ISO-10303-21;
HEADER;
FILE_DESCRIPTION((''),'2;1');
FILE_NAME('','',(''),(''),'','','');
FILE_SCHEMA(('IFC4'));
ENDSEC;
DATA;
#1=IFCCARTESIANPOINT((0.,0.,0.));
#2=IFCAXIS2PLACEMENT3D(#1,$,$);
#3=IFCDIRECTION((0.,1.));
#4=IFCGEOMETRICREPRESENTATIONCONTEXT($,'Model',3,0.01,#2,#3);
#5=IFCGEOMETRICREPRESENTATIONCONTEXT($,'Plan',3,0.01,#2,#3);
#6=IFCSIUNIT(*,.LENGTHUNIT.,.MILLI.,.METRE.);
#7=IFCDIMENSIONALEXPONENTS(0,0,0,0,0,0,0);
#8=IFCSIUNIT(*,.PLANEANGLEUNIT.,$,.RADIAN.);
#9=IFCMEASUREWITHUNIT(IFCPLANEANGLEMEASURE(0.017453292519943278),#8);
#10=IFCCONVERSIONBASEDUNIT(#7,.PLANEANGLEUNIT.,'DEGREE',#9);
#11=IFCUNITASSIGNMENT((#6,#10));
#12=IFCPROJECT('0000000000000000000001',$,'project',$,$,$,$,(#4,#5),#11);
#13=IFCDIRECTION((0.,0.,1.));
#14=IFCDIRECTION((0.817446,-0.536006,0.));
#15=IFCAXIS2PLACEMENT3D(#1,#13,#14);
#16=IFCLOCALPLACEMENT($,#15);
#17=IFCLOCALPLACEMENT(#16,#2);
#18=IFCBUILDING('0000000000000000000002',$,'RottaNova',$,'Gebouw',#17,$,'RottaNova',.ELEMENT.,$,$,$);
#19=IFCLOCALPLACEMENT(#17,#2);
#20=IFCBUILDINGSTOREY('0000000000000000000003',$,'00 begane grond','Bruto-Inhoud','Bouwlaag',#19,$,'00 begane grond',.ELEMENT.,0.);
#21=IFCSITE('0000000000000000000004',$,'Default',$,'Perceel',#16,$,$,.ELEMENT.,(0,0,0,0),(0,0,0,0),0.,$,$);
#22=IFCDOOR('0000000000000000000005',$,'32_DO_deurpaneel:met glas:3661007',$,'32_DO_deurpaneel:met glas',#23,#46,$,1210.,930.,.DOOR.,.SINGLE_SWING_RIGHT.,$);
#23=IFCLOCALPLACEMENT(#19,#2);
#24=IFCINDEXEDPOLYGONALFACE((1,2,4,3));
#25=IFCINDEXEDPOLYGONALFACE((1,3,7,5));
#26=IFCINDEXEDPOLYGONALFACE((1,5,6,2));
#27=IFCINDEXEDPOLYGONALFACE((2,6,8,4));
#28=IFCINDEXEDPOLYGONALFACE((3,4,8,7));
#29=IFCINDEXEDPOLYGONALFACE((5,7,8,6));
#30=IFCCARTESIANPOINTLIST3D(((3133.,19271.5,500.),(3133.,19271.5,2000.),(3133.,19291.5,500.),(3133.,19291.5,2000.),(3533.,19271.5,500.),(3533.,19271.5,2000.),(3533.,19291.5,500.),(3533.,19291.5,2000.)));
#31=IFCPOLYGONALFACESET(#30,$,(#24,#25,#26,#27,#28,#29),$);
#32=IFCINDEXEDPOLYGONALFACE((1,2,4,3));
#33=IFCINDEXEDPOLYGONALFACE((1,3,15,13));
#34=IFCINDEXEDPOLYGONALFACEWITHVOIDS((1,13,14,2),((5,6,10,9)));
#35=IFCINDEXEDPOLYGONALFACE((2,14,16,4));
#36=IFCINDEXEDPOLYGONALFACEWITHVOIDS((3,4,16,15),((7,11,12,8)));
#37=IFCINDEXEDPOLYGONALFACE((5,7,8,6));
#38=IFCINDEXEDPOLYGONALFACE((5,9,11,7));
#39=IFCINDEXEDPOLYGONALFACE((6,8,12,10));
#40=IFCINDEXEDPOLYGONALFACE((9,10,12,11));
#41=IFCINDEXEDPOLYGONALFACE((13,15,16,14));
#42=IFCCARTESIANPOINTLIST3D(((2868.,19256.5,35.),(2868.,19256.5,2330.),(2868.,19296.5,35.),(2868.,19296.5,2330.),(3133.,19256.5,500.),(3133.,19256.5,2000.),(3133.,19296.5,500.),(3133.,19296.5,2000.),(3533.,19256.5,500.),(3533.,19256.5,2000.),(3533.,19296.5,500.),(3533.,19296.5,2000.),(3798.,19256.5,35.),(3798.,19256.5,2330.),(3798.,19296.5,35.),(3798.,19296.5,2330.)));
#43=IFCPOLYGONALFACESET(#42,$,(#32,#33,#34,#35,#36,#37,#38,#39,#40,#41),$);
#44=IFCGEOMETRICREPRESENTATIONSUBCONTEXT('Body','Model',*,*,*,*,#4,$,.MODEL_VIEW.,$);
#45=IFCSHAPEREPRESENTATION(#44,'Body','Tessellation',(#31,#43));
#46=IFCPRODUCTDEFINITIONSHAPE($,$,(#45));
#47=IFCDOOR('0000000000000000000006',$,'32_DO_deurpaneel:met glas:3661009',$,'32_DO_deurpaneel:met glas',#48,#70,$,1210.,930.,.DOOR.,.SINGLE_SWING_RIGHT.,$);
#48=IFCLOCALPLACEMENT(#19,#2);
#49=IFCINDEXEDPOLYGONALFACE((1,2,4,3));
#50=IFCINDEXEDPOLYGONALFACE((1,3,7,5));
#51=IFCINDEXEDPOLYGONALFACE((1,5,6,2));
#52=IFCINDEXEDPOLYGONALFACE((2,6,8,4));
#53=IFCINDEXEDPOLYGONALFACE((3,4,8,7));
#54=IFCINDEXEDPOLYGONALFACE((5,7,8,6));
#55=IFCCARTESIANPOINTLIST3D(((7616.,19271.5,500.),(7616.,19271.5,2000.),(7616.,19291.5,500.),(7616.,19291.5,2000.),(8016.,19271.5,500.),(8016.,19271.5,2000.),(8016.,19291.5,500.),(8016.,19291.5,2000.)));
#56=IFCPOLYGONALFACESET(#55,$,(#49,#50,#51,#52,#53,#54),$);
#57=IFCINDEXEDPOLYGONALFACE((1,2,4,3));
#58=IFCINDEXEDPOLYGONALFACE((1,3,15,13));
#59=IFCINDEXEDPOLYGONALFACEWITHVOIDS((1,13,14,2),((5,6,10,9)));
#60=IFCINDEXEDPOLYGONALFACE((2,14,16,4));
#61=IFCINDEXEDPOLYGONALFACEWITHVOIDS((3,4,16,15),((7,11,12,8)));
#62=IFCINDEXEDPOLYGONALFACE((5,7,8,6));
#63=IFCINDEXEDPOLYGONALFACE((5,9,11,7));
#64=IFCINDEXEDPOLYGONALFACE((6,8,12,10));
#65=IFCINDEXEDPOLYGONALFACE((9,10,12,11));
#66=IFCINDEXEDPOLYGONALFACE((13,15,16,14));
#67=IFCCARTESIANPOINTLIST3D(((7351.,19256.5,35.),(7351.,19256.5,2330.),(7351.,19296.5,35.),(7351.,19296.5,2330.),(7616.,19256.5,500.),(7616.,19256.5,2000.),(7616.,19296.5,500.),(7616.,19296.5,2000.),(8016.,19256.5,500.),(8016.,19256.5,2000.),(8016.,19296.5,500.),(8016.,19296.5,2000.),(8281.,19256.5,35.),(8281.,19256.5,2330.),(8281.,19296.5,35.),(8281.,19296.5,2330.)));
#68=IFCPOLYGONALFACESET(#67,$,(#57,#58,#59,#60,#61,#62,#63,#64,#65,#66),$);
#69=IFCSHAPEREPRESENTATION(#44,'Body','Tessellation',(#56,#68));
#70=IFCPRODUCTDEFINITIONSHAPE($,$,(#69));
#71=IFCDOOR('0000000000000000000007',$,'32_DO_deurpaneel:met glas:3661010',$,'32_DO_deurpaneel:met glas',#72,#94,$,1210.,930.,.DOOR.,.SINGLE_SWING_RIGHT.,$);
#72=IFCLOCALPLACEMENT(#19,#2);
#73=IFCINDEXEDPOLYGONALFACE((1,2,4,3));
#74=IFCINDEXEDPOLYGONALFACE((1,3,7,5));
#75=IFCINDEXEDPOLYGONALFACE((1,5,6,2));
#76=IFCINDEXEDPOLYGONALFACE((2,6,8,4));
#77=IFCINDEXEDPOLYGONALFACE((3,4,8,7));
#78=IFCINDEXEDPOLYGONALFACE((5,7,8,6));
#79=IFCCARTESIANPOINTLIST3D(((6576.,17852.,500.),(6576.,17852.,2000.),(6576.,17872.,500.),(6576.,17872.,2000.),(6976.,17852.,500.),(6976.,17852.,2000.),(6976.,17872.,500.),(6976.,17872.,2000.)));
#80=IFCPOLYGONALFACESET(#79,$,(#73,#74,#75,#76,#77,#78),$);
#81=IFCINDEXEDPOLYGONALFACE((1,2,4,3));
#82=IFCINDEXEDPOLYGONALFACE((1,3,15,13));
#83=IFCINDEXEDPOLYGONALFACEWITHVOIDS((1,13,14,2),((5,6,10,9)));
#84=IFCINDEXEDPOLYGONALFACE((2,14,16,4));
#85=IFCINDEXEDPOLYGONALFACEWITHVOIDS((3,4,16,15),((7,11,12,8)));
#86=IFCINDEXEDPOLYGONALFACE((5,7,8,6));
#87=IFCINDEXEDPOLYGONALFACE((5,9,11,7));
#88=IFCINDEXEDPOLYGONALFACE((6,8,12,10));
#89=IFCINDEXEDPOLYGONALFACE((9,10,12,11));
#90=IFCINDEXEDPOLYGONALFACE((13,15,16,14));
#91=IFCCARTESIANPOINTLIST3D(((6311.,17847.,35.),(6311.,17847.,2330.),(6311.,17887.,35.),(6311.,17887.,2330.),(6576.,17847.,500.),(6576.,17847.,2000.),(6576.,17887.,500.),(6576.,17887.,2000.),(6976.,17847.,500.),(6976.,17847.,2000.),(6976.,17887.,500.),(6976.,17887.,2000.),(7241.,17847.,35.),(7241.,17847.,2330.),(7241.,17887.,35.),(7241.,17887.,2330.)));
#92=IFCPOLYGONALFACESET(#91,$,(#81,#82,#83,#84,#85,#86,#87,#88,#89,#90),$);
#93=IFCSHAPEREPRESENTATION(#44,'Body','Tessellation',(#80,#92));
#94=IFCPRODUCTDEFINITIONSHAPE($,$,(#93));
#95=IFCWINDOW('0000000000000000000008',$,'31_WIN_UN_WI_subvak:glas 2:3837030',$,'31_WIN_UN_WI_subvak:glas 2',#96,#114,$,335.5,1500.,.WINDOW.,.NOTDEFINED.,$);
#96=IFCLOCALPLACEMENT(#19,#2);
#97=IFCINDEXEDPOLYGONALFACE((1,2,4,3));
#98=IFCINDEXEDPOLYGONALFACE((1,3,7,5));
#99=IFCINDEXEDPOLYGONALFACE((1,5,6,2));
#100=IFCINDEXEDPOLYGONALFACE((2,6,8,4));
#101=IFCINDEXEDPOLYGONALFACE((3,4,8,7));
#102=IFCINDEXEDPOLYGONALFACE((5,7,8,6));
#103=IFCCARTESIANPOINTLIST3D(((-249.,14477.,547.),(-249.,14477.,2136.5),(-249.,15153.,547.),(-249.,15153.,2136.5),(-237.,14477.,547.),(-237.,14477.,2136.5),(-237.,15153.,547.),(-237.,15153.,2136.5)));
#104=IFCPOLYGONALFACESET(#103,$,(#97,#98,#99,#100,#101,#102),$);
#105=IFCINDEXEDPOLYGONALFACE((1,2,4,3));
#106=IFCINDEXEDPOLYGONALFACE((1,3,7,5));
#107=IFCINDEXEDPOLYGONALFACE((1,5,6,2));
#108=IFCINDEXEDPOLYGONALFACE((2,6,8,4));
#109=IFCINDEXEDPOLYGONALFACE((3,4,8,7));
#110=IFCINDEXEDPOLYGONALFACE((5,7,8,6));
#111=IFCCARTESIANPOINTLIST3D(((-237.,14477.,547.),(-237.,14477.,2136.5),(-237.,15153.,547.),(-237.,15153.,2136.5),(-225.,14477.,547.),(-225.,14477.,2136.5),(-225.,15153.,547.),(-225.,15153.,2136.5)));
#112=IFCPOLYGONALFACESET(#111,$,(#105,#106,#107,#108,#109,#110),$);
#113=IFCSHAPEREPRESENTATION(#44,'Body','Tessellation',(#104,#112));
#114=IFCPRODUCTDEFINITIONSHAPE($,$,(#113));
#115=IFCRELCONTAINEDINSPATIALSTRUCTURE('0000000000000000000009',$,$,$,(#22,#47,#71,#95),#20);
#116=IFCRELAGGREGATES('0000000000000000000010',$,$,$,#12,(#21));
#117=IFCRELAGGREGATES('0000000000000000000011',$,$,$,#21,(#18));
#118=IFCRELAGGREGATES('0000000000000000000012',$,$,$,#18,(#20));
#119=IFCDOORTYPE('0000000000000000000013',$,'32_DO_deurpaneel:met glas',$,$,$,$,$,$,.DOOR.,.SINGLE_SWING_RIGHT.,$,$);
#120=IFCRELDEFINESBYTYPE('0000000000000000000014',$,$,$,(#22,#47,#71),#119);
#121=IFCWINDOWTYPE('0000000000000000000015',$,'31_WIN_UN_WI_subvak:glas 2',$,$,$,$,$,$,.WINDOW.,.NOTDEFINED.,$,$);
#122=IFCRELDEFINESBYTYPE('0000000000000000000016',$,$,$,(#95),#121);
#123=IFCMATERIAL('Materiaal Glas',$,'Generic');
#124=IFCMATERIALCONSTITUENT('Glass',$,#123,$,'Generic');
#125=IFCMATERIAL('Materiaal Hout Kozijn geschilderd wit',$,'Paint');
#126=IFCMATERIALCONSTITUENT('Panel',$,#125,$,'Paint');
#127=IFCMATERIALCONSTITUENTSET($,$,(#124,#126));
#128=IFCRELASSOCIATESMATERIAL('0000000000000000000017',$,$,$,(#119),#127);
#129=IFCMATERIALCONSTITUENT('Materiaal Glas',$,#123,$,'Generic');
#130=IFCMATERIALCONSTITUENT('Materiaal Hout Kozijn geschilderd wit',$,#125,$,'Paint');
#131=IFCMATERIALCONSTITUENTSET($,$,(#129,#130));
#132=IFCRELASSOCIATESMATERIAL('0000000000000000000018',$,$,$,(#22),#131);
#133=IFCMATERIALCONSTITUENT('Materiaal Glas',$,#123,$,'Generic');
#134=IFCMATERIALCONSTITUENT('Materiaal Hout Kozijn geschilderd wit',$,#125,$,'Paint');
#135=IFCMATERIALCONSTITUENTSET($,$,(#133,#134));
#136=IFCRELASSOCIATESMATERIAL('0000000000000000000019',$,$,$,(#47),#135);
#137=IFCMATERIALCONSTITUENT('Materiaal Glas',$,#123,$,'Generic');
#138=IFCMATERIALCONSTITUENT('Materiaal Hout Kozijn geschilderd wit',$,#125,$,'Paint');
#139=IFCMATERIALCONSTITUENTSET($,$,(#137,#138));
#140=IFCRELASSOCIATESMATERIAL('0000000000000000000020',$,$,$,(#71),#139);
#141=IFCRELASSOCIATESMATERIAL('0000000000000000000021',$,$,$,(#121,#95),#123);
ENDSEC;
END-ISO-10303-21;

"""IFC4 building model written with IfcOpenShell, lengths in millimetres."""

from ifc_helpers import new_model, entity, si_unit, converted_unit, direction, frame, origin, place, context, subcontext, project, spatial, indexed_curve, outline, extrude, source, transform, mapped, material, constituent, constituent_set, type_object, type_shapes, element, save


model = new_model("IFC4")

# Units and contexts
model_context = context("Model", 3, precision=0.01, world=origin(), true_north=direction((0.0, 1.0)))
plan_context = context("Plan", 3, precision=0.01, world=origin(), true_north=direction((0.0, 1.0)))
body_context = subcontext(model_context, "Body", "Model", "MODEL_VIEW")
ifc_project = project(units=[si_unit("LENGTHUNIT", "METRE", prefix="MILLI"), converted_unit("PLANEANGLEUNIT", "DEGREE", entity("IfcPlaneAngleMeasure", 0.017453292519943278), si_unit("PLANEANGLEUNIT", "RADIAN"), dimensions=[0, 0, 0, 0, 0, 0, 0])], contexts=[model_context, plan_context])

# Site, building, storey
site_placement = place(None, frame((0.0, 0.0, 0.0), z_axis=(0.0, 0.0, 1.0), x_axis=(0.817446, -0.536006, 0.0)))
site = spatial("IfcSite", under=ifc_project, at=site_placement, Name="Default", ObjectType="Perceel", CompositionType="ELEMENT", RefLatitude=(0, 0, 0, 0), RefLongitude=(0, 0, 0, 0), RefElevation=0.0)
building_placement = place(site_placement, origin())
building = spatial("IfcBuilding", under=site, at=building_placement, Name="RottaNova", ObjectType="Gebouw", LongName="RottaNova", CompositionType="ELEMENT")
storey_placement = place(building_placement, origin())
storey = spatial("IfcBuildingStorey", under=building, at=storey_placement, Name="00 begane grond", Description="Bruto-Inhoud", ObjectType="Bouwlaag", LongName="00 begane grond", CompositionType="ELEMENT", Elevation=0.0)

# Shared definitions
ifc_material_1 = material(Name="Materiaal Glas", Category="Generic")

# Doors
ifc_constituent_1 = constituent(ifc_material_1, Name="Materiaal Glas", Category="Generic")
ifc_material_2 = material(Name="Materiaal Hout Kozijn geschilderd wit", Category="Paint")
ifc_constituent_2 = constituent(ifc_material_2, Name="Materiaal Hout Kozijn geschilderd wit", Category="Paint")
ifc_constituent_set_1 = constituent_set(constituents=[ifc_constituent_1, ifc_constituent_2])
ifc_constituent_3 = constituent(ifc_material_1, Name="Glass", Category="Generic")
ifc_constituent_4 = constituent(ifc_material_2, Name="Panel", Category="Paint")
ifc_constituent_set_2 = constituent_set(constituents=[ifc_constituent_3, ifc_constituent_4])
door_type_1 = type_object("IfcDoorType", Name="32_DO_deurpaneel:met glas", OperationType="SINGLE_SWING_RIGHT", PredefinedType="DOOR", material=ifc_constituent_set_2)
shared_shape_1 = source(origin(), body_context, "Body", "SweptSolid", [
    extrude(outline(indexed_curve([(-200.0, -10.0), (200.0, -10.0), (200.0, 10.0), (-200.0, 10.0), (-200.0, -10.0)], self_intersect=False)), frame((0.0, -25.0, 500.0), z_axis=(0.0, 0.0, 1.0), x_axis=(-1.0, 0.0, 0.0)), (0.0, 0.0, 1.0), 1500.0),
    extrude(outline(indexed_curve([(-465.0, -1147.5), (465.0, -1147.5), (465.0, 1147.5), (-465.0, 1147.5), (-465.0, -1147.5)], self_intersect=False), holes=[indexed_curve([(-200.0, 817.5), (200.0, 817.5), (200.0, -682.5), (-200.0, -682.5), (-200.0, 817.5)], self_intersect=False)]), frame((0.0, -40.0, 1182.5), z_axis=(0.0, 1.0, 0.0), x_axis=(-1.0, 0.0, 0.0)), (0.0, 0.0, 1.0), 40.0),
])
type_shapes(door_type_1, [shared_shape_1])
door_1_placement = place(storey_placement, frame((3333.0, 19256.5, 0.0), z_axis=(0.0, 0.0, 1.0), x_axis=(-1.0, 0.0, 0.0)))
element("IfcDoor", 1, at=door_1_placement, inside=storey, type_object=door_type_1, material=ifc_constituent_set_1, Name="32_DO_deurpaneel:met glas:3661007", ObjectType="32_DO_deurpaneel:met glas", OperationType="SINGLE_SWING_RIGHT", OverallHeight=1210.0, OverallWidth=930.0, PredefinedType="DOOR", context=body_context, shape_type="MappedRepresentation", body=[
    mapped(shared_shape_1, transform((0.0, 0.0, 0.0), scale=1.0)),
])
ifc_constituent_5 = constituent(ifc_material_1, Name="Materiaal Glas", Category="Generic")
ifc_constituent_6 = constituent(ifc_material_2, Name="Materiaal Hout Kozijn geschilderd wit", Category="Paint")
ifc_constituent_set_3 = constituent_set(constituents=[ifc_constituent_5, ifc_constituent_6])
door_2_placement = place(storey_placement, frame((7816.0, 19256.5, 0.0), z_axis=(0.0, 0.0, 1.0), x_axis=(-1.0, 0.0, 0.0)))
element("IfcDoor", 2, at=door_2_placement, inside=storey, type_object=door_type_1, material=ifc_constituent_set_3, Name="32_DO_deurpaneel:met glas:3661009", ObjectType="32_DO_deurpaneel:met glas", OperationType="SINGLE_SWING_RIGHT", OverallHeight=1210.0, OverallWidth=930.0, PredefinedType="DOOR", context=body_context, shape_type="MappedRepresentation", body=[
    mapped(shared_shape_1, transform((0.0, 0.0, 0.0), scale=1.0)),
])
ifc_constituent_7 = constituent(ifc_material_1, Name="Materiaal Glas", Category="Generic")
ifc_constituent_8 = constituent(ifc_material_2, Name="Materiaal Hout Kozijn geschilderd wit", Category="Paint")
ifc_constituent_set_4 = constituent_set(constituents=[ifc_constituent_7, ifc_constituent_8])
door_3_placement = place(storey_placement, frame((6776.0, 17887.0, 0.0)))
element("IfcDoor", 3, at=door_3_placement, inside=storey, type_object=door_type_1, material=ifc_constituent_set_4, Name="32_DO_deurpaneel:met glas:3661010", ObjectType="32_DO_deurpaneel:met glas", OperationType="SINGLE_SWING_RIGHT", OverallHeight=1210.0, OverallWidth=930.0, PredefinedType="DOOR", context=body_context, shape_type="MappedRepresentation", body=[
    mapped(shared_shape_1, transform((0.0, 0.0, 0.0), scale=1.0)),
])

# Window
window_type = type_object("IfcWindowType", Name="31_WIN_UN_WI_subvak:glas 2", PartitioningType="NOTDEFINED", PredefinedType="WINDOW", material=ifc_material_1)
shared_shape_2 = source(origin(), body_context, "Body", "SweptSolid", [
    extrude(outline(indexed_curve([(-6.0, -338.0), (6.0, -338.0), (6.0, 338.0), (-6.0, 338.0), (-6.0, -338.0)], self_intersect=False)), frame((0.0, 6.0, 0.0), z_axis=(0.0, 0.0, 1.0), x_axis=(0.0, -1.0, 0.0)), (0.0, 0.0, 1.0), 1589.5),
    extrude(outline(indexed_curve([(-6.0, -338.0), (6.0, -338.0), (6.0, 338.0), (-6.0, 338.0), (-6.0, -338.0)], self_intersect=False)), frame((0.0, -6.0, 0.0), z_axis=(0.0, 0.0, 1.0), x_axis=(0.0, -1.0, 0.0)), (0.0, 0.0, 1.0), 1589.5),
])
type_shapes(window_type, [shared_shape_2])
window_1_placement = place(storey_placement, frame((-237.0, 14815.0, 547.0), z_axis=(0.0, 0.0, 1.0), x_axis=(0.0, 1.0, 0.0)))
element("IfcWindow", 4, at=window_1_placement, inside=storey, type_object=window_type, material=ifc_material_1, Name="31_WIN_UN_WI_subvak:glas 2:3837030", ObjectType="31_WIN_UN_WI_subvak:glas 2", OverallHeight=335.5, OverallWidth=1500.0, PartitioningType="NOTDEFINED", PredefinedType="WINDOW", context=body_context, shape_type="MappedRepresentation", body=[
    mapped(shared_shape_2, transform((0.0, 0.0, 0.0), scale=1.0)),
])

save(model, "model.ifc")
